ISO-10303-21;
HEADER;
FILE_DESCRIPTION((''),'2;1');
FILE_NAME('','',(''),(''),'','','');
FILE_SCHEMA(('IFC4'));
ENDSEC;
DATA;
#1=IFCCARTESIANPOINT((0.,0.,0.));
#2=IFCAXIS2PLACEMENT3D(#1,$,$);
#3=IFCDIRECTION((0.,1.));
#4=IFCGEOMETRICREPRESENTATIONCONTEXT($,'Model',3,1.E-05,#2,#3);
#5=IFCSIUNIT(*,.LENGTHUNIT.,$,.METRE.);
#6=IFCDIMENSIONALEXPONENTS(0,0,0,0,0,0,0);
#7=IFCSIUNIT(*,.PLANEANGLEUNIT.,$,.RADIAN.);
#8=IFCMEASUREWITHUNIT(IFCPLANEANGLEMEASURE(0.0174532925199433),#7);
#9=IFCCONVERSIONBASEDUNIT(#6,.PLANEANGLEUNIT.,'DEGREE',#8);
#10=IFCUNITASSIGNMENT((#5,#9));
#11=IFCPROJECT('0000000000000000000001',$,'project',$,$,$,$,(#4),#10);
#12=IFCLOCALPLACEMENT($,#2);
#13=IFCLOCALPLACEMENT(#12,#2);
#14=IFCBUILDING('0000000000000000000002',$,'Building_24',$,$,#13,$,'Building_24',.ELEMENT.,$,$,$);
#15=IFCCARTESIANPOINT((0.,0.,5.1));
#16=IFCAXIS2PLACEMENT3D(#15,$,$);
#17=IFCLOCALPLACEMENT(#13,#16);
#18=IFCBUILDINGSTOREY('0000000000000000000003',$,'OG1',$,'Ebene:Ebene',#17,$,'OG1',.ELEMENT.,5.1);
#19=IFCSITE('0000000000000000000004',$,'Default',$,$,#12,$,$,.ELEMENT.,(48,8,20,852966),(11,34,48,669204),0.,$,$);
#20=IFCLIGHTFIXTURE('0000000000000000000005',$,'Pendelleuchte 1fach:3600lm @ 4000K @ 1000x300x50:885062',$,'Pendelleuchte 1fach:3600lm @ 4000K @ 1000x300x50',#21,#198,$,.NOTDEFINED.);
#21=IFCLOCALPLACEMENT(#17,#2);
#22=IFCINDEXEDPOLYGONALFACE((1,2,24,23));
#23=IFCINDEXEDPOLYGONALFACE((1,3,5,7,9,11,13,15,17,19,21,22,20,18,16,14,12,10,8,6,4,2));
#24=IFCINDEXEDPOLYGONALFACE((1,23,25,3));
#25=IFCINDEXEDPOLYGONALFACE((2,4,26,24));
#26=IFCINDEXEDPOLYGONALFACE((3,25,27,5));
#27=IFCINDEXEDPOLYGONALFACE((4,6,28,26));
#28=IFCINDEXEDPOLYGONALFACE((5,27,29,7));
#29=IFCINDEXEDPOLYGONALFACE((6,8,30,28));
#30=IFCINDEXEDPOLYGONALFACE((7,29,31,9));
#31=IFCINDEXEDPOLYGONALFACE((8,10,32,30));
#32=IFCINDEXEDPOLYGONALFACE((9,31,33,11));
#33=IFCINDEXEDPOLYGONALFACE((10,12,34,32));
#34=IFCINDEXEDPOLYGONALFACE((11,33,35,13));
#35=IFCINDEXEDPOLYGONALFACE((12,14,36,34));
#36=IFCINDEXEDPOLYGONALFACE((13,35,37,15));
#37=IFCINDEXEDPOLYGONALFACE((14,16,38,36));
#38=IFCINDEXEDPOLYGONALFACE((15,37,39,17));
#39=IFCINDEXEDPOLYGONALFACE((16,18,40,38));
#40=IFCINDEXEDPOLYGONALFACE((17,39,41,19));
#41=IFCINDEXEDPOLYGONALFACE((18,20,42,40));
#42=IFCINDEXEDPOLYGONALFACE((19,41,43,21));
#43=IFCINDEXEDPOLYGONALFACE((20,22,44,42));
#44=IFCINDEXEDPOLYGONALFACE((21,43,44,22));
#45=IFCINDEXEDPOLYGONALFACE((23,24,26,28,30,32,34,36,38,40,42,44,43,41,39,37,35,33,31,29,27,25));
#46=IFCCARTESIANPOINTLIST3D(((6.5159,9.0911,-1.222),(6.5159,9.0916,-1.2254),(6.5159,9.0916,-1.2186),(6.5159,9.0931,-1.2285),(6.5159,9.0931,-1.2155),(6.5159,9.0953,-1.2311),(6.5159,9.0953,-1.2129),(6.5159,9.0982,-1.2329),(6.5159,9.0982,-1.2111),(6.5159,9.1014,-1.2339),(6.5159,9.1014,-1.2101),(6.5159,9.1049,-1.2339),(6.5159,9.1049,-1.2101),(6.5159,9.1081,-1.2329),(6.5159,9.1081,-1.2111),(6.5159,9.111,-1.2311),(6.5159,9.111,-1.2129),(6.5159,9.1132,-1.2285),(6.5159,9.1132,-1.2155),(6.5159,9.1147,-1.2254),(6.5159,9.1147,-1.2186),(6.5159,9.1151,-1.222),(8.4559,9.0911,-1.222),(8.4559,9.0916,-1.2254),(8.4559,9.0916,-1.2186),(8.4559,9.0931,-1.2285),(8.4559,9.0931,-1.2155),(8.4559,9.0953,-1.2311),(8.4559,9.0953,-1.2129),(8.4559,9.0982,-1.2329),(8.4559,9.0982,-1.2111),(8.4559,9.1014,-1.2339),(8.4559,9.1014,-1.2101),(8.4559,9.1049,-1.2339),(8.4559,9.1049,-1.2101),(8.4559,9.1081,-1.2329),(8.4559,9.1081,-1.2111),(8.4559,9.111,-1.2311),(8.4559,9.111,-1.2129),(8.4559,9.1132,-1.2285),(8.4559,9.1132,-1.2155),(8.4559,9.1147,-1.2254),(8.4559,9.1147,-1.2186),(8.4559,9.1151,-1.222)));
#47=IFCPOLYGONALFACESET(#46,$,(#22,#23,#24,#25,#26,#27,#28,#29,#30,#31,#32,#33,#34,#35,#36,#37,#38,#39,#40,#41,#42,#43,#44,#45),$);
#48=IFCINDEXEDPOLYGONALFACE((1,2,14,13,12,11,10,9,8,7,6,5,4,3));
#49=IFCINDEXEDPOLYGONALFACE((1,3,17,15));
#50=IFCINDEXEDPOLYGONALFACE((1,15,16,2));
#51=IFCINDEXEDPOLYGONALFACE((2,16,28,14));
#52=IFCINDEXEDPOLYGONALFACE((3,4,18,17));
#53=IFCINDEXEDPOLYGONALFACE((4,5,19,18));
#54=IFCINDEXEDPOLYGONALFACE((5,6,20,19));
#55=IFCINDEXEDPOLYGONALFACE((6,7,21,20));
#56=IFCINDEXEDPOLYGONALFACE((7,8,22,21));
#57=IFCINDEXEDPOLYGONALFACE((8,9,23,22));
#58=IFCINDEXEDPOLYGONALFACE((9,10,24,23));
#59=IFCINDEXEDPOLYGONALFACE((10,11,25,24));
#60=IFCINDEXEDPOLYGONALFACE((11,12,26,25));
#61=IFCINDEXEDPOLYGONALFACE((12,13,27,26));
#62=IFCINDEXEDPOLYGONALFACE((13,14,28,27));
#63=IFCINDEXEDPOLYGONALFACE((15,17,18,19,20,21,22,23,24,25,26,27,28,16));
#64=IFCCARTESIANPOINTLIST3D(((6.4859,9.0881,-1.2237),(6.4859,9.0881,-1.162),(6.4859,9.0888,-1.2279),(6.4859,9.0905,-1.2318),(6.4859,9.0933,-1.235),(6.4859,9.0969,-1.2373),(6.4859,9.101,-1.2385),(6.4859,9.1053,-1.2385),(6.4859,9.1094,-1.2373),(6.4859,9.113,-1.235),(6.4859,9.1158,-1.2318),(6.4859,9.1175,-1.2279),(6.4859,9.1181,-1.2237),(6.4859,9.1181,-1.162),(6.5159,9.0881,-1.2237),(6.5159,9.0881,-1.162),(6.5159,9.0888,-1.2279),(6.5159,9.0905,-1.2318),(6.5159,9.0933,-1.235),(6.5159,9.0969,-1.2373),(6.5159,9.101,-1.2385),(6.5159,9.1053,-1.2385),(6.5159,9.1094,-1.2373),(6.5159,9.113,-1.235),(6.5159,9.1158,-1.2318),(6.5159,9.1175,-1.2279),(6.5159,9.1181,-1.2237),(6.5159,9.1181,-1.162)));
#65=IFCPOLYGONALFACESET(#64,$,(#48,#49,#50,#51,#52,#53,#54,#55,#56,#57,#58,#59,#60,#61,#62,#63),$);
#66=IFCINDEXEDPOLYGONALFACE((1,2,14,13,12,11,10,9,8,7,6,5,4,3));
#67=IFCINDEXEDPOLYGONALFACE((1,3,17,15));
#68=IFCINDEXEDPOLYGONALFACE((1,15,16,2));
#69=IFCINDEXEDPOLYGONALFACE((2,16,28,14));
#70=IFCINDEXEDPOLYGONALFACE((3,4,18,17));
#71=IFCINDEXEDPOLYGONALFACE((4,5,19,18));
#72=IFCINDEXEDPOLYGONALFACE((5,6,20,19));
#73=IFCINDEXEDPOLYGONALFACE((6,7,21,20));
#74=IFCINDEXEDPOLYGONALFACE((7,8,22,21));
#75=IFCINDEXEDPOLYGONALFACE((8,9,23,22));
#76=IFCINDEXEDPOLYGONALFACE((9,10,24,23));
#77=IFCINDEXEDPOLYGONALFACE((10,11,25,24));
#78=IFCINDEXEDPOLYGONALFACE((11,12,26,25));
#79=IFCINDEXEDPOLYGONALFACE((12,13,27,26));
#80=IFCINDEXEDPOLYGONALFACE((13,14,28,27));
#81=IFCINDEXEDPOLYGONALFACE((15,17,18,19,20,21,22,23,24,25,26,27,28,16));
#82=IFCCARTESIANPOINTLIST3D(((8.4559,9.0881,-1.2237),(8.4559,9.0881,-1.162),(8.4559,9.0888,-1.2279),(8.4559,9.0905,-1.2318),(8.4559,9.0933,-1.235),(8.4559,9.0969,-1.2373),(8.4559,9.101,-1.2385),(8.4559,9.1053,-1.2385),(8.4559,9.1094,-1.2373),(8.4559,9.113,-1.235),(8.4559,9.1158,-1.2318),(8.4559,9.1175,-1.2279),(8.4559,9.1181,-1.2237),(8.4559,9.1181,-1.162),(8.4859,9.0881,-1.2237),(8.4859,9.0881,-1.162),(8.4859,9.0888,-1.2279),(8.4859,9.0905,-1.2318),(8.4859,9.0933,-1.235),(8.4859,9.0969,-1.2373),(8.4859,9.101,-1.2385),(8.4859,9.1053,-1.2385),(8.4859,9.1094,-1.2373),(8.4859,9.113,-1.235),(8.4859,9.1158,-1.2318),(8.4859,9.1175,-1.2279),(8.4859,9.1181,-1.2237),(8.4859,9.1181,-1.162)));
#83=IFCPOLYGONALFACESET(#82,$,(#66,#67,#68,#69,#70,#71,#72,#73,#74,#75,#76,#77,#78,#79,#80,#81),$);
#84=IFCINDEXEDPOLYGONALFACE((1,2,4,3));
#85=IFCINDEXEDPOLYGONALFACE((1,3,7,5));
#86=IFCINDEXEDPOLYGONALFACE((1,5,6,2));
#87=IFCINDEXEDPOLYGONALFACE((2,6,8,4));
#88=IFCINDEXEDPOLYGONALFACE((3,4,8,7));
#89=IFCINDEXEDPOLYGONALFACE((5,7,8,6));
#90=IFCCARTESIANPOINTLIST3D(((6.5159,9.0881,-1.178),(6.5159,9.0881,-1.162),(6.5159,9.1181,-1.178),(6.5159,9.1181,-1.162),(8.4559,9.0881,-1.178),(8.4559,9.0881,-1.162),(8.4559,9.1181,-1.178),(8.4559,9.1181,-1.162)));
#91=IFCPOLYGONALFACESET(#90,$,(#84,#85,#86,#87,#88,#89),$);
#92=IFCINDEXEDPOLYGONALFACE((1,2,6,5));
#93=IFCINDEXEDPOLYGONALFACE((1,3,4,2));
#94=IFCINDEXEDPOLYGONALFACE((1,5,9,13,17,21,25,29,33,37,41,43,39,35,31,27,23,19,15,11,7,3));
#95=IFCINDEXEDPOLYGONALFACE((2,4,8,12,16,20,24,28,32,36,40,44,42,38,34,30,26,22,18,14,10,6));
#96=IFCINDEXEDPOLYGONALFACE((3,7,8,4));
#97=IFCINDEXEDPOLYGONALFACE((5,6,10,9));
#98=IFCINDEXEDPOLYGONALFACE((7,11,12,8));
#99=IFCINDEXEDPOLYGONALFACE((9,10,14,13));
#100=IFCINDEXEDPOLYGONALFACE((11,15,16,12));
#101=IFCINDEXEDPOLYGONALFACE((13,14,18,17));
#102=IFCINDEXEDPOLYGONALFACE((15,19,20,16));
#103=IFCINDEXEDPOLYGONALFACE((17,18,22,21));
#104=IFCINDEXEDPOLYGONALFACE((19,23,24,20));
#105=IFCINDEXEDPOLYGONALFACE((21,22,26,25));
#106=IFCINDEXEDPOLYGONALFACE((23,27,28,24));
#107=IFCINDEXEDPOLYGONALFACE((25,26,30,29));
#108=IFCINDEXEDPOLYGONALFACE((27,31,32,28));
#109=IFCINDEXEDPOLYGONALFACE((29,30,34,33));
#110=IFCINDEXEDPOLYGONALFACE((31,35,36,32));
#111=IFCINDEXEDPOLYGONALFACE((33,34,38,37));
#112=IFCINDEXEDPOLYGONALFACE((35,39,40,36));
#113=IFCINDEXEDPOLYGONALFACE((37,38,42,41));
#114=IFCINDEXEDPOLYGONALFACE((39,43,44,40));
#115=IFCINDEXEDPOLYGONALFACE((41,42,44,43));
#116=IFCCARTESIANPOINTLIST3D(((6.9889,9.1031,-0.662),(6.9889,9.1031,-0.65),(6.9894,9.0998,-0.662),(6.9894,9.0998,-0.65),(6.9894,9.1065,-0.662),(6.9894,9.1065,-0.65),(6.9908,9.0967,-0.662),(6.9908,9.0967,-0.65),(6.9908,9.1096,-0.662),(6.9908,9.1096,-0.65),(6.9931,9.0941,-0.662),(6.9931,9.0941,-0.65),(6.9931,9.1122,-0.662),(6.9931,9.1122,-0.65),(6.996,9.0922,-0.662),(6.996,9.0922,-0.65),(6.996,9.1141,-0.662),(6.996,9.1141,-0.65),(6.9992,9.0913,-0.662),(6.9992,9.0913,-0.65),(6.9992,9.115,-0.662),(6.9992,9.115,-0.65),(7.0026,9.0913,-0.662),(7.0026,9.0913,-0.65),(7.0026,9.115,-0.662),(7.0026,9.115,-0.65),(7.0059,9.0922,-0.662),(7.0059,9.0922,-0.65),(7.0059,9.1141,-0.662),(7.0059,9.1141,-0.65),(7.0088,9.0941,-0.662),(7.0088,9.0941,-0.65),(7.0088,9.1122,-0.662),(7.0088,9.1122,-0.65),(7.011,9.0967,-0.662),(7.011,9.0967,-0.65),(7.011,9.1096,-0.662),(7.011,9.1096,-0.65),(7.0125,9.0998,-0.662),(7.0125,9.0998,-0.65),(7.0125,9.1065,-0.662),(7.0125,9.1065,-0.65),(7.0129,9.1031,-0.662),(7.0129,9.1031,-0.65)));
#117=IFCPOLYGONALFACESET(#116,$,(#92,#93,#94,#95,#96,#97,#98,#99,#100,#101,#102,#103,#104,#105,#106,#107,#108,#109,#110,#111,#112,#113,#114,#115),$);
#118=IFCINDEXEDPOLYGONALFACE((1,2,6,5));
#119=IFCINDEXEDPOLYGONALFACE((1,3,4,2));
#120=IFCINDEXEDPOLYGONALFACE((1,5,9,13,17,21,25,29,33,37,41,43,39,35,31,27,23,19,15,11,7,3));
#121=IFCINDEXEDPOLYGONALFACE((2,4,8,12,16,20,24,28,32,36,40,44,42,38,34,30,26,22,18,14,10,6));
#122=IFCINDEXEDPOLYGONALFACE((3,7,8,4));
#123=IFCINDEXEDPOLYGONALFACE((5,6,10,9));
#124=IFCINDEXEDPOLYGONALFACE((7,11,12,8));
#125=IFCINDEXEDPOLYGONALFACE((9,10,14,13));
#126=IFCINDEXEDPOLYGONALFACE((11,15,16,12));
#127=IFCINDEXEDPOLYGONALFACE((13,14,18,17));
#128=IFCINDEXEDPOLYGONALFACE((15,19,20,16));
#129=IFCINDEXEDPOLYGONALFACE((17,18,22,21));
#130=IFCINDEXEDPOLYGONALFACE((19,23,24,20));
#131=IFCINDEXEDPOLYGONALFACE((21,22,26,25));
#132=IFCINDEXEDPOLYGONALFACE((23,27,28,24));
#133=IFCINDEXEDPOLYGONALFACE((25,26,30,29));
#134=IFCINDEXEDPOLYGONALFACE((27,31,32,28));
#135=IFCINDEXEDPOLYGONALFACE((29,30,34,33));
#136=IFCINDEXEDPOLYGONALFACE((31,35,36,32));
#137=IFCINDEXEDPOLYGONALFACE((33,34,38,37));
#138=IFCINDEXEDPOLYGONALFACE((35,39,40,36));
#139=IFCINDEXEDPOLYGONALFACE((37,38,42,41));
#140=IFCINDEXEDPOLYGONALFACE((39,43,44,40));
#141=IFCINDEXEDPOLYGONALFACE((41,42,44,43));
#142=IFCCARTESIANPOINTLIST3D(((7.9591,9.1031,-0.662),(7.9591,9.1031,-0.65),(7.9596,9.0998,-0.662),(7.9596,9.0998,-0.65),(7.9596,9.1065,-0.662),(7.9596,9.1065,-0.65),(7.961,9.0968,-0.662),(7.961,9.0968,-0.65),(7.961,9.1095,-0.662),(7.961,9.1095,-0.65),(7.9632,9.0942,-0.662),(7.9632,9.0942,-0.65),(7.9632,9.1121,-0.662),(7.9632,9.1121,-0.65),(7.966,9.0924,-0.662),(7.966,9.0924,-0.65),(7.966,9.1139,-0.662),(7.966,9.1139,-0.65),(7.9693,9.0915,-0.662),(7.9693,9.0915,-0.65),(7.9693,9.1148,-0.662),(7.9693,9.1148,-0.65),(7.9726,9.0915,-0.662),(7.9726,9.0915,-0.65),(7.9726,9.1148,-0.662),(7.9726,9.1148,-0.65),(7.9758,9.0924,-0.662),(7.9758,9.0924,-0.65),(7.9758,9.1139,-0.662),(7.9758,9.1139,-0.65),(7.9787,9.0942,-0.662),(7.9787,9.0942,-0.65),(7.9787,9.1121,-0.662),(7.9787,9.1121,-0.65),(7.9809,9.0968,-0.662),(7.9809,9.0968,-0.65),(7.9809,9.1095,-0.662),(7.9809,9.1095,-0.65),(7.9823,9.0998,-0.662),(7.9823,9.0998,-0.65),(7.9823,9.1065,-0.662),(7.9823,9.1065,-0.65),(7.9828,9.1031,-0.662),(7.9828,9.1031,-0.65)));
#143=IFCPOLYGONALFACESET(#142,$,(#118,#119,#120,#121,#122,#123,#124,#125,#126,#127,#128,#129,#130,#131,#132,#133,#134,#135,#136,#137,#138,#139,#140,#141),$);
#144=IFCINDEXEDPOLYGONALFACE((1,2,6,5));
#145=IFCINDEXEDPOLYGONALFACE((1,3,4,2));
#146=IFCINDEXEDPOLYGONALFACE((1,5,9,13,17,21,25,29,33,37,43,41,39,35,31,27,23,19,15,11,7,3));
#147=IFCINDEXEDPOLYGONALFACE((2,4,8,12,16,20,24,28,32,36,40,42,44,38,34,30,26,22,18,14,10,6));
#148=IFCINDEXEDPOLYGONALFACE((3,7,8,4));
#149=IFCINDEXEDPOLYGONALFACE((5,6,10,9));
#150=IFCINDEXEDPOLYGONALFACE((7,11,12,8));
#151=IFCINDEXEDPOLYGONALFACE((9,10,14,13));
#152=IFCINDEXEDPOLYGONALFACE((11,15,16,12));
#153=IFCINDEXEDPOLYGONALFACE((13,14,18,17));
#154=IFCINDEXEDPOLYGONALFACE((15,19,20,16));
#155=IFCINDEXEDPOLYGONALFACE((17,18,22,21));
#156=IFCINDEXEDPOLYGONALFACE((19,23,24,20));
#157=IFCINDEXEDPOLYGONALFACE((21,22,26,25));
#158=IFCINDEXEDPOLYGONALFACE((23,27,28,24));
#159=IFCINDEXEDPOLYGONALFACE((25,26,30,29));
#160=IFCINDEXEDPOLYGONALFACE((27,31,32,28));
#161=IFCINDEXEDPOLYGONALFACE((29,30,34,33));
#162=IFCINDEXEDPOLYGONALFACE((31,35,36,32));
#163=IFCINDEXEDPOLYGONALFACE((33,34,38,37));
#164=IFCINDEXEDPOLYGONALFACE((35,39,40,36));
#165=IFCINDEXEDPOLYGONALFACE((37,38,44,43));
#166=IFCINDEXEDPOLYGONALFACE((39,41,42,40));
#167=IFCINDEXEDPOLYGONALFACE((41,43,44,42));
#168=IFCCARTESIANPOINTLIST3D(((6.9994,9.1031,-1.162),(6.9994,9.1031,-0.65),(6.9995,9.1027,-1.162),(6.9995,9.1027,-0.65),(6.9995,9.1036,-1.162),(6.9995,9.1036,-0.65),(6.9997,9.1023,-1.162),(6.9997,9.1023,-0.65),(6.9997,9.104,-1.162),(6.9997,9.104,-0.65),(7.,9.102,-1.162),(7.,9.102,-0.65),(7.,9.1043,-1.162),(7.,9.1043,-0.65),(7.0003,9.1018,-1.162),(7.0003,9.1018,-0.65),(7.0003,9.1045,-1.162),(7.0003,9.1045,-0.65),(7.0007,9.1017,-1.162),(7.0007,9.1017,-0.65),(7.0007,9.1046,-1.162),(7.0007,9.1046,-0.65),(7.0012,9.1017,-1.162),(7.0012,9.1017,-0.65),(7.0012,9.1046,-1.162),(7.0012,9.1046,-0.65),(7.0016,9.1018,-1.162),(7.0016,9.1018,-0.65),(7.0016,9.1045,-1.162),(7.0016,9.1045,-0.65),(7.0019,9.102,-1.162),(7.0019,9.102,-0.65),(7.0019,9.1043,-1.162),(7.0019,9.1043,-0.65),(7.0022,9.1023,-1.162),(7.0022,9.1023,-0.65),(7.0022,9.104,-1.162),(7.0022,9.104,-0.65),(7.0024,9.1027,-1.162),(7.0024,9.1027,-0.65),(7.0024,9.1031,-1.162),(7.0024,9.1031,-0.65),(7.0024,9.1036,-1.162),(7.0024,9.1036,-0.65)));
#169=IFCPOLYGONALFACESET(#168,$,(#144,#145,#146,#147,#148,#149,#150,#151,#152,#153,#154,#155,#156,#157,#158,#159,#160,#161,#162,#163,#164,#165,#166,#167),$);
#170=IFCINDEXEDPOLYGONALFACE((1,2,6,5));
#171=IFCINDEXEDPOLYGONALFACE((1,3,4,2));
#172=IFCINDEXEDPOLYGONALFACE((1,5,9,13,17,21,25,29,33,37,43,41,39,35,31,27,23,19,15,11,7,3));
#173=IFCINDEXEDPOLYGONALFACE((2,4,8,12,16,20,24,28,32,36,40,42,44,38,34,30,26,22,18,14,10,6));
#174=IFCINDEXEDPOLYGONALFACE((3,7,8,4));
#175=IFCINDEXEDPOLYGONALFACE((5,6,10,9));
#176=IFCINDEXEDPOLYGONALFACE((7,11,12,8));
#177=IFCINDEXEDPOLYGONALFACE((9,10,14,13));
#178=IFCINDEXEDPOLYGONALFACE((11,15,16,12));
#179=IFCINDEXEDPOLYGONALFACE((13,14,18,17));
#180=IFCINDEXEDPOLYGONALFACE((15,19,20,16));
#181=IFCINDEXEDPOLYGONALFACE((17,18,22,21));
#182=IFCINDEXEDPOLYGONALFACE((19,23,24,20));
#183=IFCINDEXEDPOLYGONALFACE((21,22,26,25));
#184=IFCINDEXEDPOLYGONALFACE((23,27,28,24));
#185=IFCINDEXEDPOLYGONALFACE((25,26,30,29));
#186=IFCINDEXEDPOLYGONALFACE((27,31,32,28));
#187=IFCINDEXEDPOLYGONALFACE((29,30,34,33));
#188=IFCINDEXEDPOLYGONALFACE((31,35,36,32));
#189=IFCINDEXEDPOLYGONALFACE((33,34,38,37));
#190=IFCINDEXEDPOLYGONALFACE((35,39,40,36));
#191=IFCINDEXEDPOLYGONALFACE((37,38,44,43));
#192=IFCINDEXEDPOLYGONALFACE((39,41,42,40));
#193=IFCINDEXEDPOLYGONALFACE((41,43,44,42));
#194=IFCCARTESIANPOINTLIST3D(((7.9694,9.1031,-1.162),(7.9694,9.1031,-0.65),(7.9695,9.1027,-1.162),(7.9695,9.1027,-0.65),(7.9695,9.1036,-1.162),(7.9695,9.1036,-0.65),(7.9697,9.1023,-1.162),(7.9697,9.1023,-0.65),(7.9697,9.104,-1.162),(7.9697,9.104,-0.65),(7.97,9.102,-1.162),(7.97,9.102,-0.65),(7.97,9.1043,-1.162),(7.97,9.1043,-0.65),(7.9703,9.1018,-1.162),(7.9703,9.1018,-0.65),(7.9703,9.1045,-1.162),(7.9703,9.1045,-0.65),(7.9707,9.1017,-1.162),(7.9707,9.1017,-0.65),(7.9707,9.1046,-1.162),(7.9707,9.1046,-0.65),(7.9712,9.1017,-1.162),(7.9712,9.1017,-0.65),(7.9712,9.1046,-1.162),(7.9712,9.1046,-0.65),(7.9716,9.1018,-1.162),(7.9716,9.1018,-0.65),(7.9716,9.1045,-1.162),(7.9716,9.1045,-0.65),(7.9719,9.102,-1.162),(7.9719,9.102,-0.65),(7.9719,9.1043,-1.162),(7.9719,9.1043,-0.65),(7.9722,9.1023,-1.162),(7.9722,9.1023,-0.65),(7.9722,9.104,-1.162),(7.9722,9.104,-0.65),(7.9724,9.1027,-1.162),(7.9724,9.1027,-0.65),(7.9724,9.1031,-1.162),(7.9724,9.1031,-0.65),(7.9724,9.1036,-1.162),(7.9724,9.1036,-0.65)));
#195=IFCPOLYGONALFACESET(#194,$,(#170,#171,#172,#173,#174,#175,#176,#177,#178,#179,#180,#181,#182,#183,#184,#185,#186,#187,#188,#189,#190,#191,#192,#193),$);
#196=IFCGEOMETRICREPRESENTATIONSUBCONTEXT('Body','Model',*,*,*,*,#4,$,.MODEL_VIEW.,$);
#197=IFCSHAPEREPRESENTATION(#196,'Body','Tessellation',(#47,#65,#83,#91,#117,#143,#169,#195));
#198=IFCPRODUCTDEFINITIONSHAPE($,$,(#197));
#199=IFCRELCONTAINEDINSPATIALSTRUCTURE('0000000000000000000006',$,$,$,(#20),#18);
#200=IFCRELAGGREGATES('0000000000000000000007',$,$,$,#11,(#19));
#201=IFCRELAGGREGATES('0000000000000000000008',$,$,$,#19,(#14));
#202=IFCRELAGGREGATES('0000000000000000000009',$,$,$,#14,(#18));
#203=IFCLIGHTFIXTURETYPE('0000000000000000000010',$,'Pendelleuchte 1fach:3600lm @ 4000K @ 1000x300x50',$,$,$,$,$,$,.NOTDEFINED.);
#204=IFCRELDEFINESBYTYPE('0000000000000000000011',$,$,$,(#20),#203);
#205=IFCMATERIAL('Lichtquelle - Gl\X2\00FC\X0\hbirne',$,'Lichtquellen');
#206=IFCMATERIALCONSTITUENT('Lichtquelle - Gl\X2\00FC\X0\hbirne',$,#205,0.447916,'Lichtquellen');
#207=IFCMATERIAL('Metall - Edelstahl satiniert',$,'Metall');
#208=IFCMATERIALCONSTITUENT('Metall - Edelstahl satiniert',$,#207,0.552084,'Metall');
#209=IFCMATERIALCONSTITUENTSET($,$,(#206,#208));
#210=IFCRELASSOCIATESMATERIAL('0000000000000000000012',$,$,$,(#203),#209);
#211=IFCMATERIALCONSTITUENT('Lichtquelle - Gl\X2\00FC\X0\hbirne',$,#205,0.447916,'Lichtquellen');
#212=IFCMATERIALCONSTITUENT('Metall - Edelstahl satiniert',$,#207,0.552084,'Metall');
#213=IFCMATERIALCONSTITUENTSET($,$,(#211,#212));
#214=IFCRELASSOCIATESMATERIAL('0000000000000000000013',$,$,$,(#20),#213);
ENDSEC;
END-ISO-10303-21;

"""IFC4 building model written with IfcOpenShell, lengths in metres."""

from ifc_helpers import new_model, entity, si_unit, converted_unit, direction, frame, origin, place, context, subcontext, project, spatial, line, arc, indexed_curve, outline, extrude, source, transform, mapped, material, constituent, constituent_set, type_object, type_shapes, element, save


model = new_model("IFC4")

# Units and contexts
model_context = context("Model", 3, precision=1e-05, world=origin(), true_north=direction((0.0, 1.0)))
body_context = subcontext(model_context, "Body", "Model", "MODEL_VIEW")
ifc_project = project(units=[si_unit("LENGTHUNIT", "METRE"), converted_unit("PLANEANGLEUNIT", "DEGREE", entity("IfcPlaneAngleMeasure", 0.0174532925199433), si_unit("PLANEANGLEUNIT", "RADIAN"), dimensions=[0, 0, 0, 0, 0, 0, 0])], contexts=[model_context])

# Site, building, storey
site_placement = place(None, origin())
site = spatial("IfcSite", under=ifc_project, at=site_placement, Name="Default", CompositionType="ELEMENT", RefLatitude=(48, 8, 20, 852966), RefLongitude=(11, 34, 48, 669204), RefElevation=0.0)
building_placement = place(site_placement, origin())
building = spatial("IfcBuilding", under=site, at=building_placement, Name="Building_24", LongName="Building_24", CompositionType="ELEMENT")
storey_placement = place(building_placement, frame((0.0, 0.0, 5.1)))
storey = spatial("IfcBuildingStorey", under=building, at=storey_placement, Name="OG1", ObjectType="Ebene:Ebene", LongName="OG1", CompositionType="ELEMENT", Elevation=5.1)

# Light fixture
ifc_material_1 = material(Name="Lichtquelle - Glühbirne", Category="Lichtquellen")
ifc_material_2 = material(Name="Metall - Edelstahl satiniert", Category="Metall")
ifc_constituent_1 = constituent(ifc_material_1, Name="Lichtquelle - Glühbirne", Category="Lichtquellen", fraction=0.447916)
ifc_constituent_2 = constituent(ifc_material_2, Name="Metall - Edelstahl satiniert", Category="Metall", fraction=0.552084)
ifc_constituent_set_1 = constituent_set(constituents=[ifc_constituent_1, ifc_constituent_2])
light_fixture_type = type_object("IfcLightFixtureType", Name="Pendelleuchte 1fach:3600lm @ 4000K @ 1000x300x50", PredefinedType="NOTDEFINED", material=ifc_constituent_set_1)
shared_shape_1 = source(origin(), body_context, "Body", "SweptSolid", [
    extrude(outline(indexed_curve([(-0.012, 0.0), (0.0, -0.012), (0.012, 0.0), (0.0, 0.012)], segments=[arc(1, 2, 3), arc(3, 4, 1)], self_intersect=False)), frame((-0.97, 0.0, -0.572), z_axis=(1.0, 0.0, 0.0), x_axis=(0.0, -1.0, 0.0)), (0.0, 0.0, 1.0), 1.94),
    extrude(outline(indexed_curve([(0.015, 0.0308), (0.0, 0.0458), (-0.015, 0.0308), (-0.015, -0.0308), (0.015, -0.0308)], segments=[arc(1, 2, 3), line(3, 4, 5, 1)], self_intersect=False)), frame((0.97, 0.0, -0.5428), z_axis=(1.0, 0.0, 0.0), x_axis=(0.0, -1.0, 0.0)), (0.0, 0.0, 1.0), 0.03),
    extrude(outline(indexed_curve([(0.015, 0.0308), (0.0, 0.0458), (-0.015, 0.0308), (-0.015, -0.0308), (0.015, -0.0308)], segments=[arc(1, 2, 3), line(3, 4, 5, 1)], self_intersect=False)), frame((-1.0, 0.0, -0.5428), z_axis=(1.0, 0.0, 0.0), x_axis=(0.0, -1.0, 0.0)), (0.0, 0.0, 1.0), 0.03),
    extrude(outline(indexed_curve([(-0.015, -0.97), (0.015, -0.97), (0.015, 0.97), (-0.015, 0.97), (-0.015, -0.97)], self_intersect=False)), frame((0.0, 0.0, -0.528), z_axis=(0.0, 0.0, 1.0), x_axis=(0.0, 1.0, 0.0)), (0.0, 0.0, 1.0), 0.016),
    extrude(outline(indexed_curve([(-0.012, 0.0), (0.0, -0.012), (0.012, 0.0), (0.0, 0.012)], segments=[arc(1, 2, 3), arc(3, 4, 1)], self_intersect=False)), frame((0.485, 0.0, -0.012)), (0.0, 0.0, 1.0), 0.012),
    extrude(outline(indexed_curve([(-0.0118, 0.0), (0.0, -0.0118), (0.0118, 0.0), (0.0, 0.0118)], segments=[arc(1, 2, 3), arc(3, 4, 1)], self_intersect=False)), frame((-0.485, 0.0, -0.012)), (0.0, 0.0, 1.0), 0.012),
    extrude(outline(indexed_curve([(-0.0015, 0.0), (0.0, -0.0015), (0.0015, 0.0), (0.0, 0.0015)], segments=[arc(1, 2, 3), arc(3, 4, 1)], self_intersect=False)), frame((0.485, 0.0, -0.512)), (0.0, 0.0, 1.0), 0.512),
    extrude(outline(indexed_curve([(-0.0015, 0.0), (0.0, -0.0015), (0.0015, 0.0), (0.0, 0.0015)], segments=[arc(1, 2, 3), arc(3, 4, 1)], self_intersect=False)), frame((-0.485, 0.0, -0.512)), (0.0, 0.0, 1.0), 0.512),
])
type_shapes(light_fixture_type, [shared_shape_1])
ifc_constituent_3 = constituent(ifc_material_1, Name="Lichtquelle - Glühbirne", Category="Lichtquellen", fraction=0.447916)
ifc_constituent_4 = constituent(ifc_material_2, Name="Metall - Edelstahl satiniert", Category="Metall", fraction=0.552084)
ifc_constituent_set_2 = constituent_set(constituents=[ifc_constituent_3, ifc_constituent_4])
light_fixture_1_placement = place(storey_placement, frame((7.4859, 9.1031, -0.65), z_axis=(0.0, 0.0, 1.0), x_axis=(-1.0, 0.0, 0.0)))
element("IfcLightFixture", 1, at=light_fixture_1_placement, inside=storey, type_object=light_fixture_type, material=ifc_constituent_set_2, Name="Pendelleuchte 1fach:3600lm @ 4000K @ 1000x300x50:885062", ObjectType="Pendelleuchte 1fach:3600lm @ 4000K @ 1000x300x50", PredefinedType="NOTDEFINED", context=body_context, shape_type="MappedRepresentation", body=[
    mapped(shared_shape_1, transform((0.0, 0.0, 0.0), scale=1.0)),
])

save(model, "model.ifc")
